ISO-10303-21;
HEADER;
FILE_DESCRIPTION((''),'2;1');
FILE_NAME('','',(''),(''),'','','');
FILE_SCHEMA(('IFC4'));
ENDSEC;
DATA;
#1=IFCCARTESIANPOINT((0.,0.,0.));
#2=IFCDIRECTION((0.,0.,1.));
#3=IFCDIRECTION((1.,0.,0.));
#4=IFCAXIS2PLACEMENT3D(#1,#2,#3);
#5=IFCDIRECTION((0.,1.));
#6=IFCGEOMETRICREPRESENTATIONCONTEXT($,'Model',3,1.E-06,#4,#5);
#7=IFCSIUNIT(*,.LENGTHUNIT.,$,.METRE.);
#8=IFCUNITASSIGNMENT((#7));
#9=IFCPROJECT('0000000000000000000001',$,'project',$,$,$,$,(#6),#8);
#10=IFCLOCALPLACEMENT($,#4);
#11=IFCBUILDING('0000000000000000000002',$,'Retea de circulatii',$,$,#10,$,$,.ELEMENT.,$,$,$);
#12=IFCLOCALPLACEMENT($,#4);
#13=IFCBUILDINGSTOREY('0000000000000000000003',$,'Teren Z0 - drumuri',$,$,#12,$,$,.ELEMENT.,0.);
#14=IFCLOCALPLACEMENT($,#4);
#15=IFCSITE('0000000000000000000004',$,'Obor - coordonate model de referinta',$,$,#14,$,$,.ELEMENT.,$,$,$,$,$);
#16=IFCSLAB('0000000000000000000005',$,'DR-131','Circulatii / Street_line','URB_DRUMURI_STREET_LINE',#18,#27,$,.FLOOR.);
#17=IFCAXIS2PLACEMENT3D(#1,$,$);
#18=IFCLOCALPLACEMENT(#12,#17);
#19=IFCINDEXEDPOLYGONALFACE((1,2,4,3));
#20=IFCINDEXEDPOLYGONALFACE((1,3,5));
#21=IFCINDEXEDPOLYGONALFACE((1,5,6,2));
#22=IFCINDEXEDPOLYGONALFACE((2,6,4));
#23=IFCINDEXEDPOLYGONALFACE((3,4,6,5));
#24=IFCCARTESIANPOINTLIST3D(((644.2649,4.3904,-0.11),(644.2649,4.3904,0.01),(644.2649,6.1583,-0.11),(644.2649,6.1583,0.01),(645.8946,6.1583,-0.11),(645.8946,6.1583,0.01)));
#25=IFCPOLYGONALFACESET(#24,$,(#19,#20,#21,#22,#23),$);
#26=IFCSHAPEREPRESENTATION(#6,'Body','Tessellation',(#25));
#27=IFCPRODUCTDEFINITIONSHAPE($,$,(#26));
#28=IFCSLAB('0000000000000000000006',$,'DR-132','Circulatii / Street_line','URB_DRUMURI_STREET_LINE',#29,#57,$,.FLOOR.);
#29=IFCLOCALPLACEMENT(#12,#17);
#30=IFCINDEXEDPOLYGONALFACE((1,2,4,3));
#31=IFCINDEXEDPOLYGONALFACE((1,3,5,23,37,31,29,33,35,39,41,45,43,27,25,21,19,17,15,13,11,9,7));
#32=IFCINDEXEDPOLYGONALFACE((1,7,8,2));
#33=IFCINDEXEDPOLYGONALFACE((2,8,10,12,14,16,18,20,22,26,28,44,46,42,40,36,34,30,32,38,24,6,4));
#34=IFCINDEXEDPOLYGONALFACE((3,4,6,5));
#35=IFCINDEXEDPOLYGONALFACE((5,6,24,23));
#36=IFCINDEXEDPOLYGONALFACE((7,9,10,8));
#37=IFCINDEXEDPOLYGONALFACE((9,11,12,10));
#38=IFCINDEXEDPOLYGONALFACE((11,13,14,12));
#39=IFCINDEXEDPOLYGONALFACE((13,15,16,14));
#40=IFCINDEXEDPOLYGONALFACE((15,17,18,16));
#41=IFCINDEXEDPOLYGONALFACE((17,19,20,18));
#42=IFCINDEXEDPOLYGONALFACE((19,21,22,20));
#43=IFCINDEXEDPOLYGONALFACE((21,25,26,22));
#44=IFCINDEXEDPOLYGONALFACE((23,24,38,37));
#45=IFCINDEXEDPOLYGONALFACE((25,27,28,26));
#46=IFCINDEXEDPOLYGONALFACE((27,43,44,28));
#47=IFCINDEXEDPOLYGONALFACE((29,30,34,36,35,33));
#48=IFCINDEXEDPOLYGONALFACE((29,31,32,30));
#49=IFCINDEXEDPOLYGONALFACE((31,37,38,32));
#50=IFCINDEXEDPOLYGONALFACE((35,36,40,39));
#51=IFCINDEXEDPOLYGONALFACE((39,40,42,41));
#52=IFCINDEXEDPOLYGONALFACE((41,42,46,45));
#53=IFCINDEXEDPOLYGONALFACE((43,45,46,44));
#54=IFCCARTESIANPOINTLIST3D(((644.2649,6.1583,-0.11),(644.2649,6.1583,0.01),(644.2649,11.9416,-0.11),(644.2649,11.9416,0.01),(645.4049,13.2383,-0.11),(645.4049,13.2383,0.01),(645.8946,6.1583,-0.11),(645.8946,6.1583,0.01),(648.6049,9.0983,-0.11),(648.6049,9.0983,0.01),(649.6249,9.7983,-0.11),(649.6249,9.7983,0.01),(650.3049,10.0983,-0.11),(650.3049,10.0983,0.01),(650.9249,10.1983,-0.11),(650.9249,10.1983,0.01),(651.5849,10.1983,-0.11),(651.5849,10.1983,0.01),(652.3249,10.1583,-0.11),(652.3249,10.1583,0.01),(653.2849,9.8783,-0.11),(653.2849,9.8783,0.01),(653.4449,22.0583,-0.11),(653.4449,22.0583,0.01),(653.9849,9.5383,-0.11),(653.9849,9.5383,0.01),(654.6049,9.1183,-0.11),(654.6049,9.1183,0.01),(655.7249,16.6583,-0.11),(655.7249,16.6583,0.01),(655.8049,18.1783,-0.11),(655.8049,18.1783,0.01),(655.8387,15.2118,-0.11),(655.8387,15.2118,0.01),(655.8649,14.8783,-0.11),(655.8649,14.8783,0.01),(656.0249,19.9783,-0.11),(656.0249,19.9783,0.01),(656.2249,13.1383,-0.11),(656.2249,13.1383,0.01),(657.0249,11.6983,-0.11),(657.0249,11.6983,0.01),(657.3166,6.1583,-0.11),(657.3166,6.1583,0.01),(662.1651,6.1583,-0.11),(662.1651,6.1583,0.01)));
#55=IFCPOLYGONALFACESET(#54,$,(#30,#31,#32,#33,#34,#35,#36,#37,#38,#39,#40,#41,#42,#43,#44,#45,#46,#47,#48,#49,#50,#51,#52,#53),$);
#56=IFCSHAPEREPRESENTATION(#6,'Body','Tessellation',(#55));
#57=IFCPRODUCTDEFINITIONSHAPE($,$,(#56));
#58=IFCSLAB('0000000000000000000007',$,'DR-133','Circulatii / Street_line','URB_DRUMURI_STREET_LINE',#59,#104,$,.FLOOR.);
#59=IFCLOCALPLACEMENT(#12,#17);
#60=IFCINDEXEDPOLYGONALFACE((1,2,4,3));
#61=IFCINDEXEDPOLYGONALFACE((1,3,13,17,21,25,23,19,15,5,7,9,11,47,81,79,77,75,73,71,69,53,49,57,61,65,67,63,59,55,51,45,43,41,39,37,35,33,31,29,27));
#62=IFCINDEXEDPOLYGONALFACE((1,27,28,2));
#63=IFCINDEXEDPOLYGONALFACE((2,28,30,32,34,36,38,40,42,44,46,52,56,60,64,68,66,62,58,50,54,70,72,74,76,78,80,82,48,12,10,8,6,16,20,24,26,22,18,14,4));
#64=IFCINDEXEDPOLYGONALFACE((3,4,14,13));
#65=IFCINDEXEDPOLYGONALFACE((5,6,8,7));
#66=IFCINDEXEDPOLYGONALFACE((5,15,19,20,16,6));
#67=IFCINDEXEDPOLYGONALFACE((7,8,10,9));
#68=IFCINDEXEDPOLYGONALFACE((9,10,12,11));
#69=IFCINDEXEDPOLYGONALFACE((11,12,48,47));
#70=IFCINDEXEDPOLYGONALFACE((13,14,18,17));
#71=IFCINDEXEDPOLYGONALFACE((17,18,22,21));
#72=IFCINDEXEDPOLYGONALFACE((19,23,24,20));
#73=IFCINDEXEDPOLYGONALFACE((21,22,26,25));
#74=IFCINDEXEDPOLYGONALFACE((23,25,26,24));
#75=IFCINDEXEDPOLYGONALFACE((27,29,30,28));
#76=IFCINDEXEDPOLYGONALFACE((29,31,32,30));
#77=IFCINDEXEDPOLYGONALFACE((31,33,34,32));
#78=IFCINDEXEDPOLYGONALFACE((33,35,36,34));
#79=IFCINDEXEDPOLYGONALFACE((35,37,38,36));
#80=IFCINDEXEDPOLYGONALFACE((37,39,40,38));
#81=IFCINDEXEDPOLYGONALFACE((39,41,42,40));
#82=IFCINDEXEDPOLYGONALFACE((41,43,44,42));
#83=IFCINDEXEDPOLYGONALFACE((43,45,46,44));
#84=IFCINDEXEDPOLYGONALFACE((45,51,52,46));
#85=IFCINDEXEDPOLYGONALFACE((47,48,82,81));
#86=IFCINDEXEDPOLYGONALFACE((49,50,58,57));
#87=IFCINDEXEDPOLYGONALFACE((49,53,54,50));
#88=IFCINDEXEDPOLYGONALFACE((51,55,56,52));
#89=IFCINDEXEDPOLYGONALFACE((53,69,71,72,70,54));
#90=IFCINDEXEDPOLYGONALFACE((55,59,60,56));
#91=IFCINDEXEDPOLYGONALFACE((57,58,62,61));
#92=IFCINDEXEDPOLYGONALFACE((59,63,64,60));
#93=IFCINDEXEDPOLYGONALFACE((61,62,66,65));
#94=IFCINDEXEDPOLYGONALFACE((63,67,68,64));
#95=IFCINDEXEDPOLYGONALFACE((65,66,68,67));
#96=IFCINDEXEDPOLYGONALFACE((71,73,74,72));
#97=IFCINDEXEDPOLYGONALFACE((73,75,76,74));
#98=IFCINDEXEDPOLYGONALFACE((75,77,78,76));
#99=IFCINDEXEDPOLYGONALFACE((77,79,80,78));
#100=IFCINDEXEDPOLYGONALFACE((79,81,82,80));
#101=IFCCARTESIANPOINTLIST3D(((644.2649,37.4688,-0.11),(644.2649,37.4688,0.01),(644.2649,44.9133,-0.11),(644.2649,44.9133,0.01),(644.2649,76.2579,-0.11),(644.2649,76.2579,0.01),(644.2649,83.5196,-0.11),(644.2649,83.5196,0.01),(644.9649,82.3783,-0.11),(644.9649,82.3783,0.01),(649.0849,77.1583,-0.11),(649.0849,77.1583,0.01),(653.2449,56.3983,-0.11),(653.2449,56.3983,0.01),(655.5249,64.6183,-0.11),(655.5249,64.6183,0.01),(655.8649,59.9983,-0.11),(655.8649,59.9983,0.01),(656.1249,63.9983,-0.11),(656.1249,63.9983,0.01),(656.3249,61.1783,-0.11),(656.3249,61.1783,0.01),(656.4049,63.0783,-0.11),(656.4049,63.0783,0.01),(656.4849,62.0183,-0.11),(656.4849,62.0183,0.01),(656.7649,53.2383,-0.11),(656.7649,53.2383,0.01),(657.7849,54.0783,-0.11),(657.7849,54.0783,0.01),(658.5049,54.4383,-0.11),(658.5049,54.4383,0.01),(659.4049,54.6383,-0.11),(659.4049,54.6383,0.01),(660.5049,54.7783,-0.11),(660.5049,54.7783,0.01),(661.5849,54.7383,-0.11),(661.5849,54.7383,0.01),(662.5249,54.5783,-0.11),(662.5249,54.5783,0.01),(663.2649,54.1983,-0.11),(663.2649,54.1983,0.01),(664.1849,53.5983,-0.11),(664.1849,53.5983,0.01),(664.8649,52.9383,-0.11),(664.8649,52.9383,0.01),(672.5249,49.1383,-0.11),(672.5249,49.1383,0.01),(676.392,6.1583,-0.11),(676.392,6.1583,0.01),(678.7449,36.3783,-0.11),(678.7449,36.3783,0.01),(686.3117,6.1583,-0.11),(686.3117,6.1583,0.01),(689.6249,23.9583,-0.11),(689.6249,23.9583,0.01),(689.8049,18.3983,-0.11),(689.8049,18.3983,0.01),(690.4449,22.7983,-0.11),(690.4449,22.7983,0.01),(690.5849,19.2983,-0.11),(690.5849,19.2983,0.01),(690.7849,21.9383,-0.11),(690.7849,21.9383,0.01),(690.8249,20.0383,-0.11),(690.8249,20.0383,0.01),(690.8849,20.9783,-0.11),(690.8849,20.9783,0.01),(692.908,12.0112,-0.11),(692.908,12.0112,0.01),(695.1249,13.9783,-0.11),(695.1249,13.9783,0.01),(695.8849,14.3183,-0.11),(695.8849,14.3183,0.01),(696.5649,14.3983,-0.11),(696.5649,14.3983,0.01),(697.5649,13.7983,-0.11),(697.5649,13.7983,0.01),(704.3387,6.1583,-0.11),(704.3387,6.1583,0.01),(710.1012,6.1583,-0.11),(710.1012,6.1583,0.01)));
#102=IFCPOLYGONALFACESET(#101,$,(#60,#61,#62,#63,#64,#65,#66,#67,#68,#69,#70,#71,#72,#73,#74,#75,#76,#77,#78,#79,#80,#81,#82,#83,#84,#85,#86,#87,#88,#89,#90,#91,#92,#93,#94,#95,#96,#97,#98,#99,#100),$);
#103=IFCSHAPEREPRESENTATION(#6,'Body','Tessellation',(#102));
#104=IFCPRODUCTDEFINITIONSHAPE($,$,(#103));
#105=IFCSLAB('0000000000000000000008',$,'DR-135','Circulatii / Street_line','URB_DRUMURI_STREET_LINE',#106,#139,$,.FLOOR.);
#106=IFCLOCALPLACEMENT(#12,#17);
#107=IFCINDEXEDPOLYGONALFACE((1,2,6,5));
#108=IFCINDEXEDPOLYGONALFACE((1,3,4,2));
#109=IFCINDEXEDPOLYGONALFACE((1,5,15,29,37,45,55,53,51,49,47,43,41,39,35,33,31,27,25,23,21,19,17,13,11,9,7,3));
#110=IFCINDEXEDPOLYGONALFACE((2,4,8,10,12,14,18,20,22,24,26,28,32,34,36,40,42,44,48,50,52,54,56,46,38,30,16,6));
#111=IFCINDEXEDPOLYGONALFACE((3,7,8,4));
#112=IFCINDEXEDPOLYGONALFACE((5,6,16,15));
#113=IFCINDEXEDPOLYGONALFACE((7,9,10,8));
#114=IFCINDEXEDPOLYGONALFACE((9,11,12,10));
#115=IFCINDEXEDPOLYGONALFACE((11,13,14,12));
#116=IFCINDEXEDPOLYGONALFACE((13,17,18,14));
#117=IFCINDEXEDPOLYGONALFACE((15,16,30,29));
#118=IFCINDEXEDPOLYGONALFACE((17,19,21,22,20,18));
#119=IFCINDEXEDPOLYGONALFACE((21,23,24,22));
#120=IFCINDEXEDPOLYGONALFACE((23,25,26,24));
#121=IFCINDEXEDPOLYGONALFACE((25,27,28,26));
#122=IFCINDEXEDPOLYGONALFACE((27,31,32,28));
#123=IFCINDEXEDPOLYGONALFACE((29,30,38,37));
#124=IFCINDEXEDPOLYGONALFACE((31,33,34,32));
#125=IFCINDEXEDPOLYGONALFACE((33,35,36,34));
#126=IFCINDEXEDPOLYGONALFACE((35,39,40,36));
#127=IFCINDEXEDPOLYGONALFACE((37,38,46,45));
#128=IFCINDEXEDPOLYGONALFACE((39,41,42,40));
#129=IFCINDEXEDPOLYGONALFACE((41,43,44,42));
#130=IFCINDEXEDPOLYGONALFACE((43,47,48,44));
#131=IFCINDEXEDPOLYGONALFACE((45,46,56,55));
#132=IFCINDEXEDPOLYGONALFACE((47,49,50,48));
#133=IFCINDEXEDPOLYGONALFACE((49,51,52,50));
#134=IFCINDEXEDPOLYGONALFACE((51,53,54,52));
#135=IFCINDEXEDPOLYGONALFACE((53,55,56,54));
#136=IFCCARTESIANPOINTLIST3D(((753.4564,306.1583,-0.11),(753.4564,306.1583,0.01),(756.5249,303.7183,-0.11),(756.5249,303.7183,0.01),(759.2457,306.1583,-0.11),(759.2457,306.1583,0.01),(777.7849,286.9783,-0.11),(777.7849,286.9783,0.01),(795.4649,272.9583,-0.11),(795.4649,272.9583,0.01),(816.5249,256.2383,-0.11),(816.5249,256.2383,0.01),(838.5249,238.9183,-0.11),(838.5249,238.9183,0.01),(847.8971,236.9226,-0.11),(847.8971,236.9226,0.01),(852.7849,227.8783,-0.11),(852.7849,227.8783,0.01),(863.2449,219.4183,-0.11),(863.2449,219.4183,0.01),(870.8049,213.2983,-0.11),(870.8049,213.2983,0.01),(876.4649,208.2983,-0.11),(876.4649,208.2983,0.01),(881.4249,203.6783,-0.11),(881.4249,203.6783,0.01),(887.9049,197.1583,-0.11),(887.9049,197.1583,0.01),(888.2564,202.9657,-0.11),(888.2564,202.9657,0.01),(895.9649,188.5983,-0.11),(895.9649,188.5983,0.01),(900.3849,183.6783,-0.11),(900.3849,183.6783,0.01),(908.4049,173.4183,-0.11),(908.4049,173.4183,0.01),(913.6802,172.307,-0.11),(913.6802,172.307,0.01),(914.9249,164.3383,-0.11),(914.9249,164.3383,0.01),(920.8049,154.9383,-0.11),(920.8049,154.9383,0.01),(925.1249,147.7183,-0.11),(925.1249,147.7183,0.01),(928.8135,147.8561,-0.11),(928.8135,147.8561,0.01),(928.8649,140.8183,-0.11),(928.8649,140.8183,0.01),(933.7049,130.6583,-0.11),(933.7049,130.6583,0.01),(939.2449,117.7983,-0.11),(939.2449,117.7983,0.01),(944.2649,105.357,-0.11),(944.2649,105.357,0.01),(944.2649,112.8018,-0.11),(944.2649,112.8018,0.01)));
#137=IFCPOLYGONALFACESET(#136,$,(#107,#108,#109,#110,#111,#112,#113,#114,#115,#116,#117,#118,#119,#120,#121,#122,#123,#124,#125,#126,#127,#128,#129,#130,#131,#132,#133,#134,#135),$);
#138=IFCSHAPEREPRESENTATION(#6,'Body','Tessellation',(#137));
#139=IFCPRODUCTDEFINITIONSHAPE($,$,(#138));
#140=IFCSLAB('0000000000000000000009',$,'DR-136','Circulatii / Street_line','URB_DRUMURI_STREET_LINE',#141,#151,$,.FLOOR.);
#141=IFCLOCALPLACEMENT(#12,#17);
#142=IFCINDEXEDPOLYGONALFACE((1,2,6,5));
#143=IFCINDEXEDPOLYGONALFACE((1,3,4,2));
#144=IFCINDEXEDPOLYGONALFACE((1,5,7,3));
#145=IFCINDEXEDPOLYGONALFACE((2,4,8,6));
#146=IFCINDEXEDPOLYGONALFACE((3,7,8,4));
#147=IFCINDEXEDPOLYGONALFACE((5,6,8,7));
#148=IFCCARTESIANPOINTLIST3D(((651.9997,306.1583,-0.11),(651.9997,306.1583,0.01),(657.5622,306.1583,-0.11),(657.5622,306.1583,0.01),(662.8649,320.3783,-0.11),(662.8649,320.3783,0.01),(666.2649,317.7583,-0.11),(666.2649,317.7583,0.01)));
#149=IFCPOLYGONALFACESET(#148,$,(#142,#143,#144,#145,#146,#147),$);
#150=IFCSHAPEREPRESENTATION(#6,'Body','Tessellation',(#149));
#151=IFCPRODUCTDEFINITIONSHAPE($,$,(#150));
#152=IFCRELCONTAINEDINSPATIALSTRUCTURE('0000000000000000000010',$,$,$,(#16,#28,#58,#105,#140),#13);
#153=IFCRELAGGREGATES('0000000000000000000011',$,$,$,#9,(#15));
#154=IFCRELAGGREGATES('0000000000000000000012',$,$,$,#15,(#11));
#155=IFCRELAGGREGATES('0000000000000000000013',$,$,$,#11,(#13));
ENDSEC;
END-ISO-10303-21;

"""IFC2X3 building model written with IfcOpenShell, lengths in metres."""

from ifc_helpers import new_model, si_unit, direction, frame, origin_with_axes, place, context, project, spatial, polyline, outline, extrude, element, save


model = new_model("IFC2X3")

# Units and contexts
model_context = context("Model", 3, precision=1e-06, world=origin_with_axes(), true_north=direction((0.0, 1.0)))
ifc_project = project(units=[si_unit("LENGTHUNIT", "METRE")], contexts=[model_context])

# Site, building, storey
site_placement = place(None, origin_with_axes())
site = spatial("IfcSite", under=ifc_project, at=site_placement, Name="Obor - coordonate model de referinta", CompositionType="ELEMENT")
building_placement = place(None, origin_with_axes())
building = spatial("IfcBuilding", under=site, at=building_placement, Name="Retea de circulatii", CompositionType="ELEMENT")
storey_placement = place(None, origin_with_axes())
storey = spatial("IfcBuildingStorey", under=building, at=storey_placement, Name="Teren Z0 - drumuri", CompositionType="ELEMENT", Elevation=0.0)

# Slabs
slab_1_placement = place(None, origin_with_axes())
element("IfcSlab", 1, at=slab_1_placement, inside=storey, Name="DR-131", Description="Circulatii / Street_line", ObjectType="URB_DRUMURI_STREET_LINE", PredefinedType="FLOOR", context=model_context, shape_type="SweptSolid", body=[
    extrude(outline(polyline([(645.8946, 6.1583), (644.2649, 6.1583), (644.2649, 4.3904), (645.8946, 6.1583)])), frame((0.0, 0.0, -0.11), z_axis=(0.0, 0.0, 1.0), x_axis=(1.0, 0.0, 0.0)), (0.0, 0.0, 1.0), 0.12),
])
slab_2_placement = place(None, origin_with_axes())
element("IfcSlab", 2, at=slab_2_placement, inside=storey, Name="DR-132", Description="Circulatii / Street_line", ObjectType="URB_DRUMURI_STREET_LINE", PredefinedType="FLOOR", context=model_context, shape_type="SweptSolid", body=[
    extrude(outline(polyline([(653.2849, 9.8783), (653.9849, 9.5383), (654.6049, 9.1183), (657.3166, 6.1583), (662.1651, 6.1583), (657.0249, 11.6983), (656.2249, 13.1383), (655.8649, 14.8783), (655.8387, 15.2118), (655.7249, 16.6583), (655.8049, 18.1783), (656.0249, 19.9783), (653.4449, 22.0583), (645.4049, 13.2383), (644.2649, 11.9416), (644.2649, 6.1583), (645.8946, 6.1583), (648.6049, 9.0983), (649.6249, 9.7983), (650.3049, 10.0983), (650.9249, 10.1983), (651.5849, 10.1983), (652.3249, 10.1583), (653.2849, 9.8783)])), frame((0.0, 0.0, -0.11), z_axis=(0.0, 0.0, 1.0), x_axis=(1.0, 0.0, 0.0)), (0.0, 0.0, 1.0), 0.12),
])
slab_3_placement = place(None, origin_with_axes())
element("IfcSlab", 3, at=slab_3_placement, inside=storey, Name="DR-133", Description="Circulatii / Street_line", ObjectType="URB_DRUMURI_STREET_LINE", PredefinedType="FLOOR", context=model_context, shape_type="SweptSolid", body=[
    extrude(outline(polyline([(695.8849, 14.3183), (696.5649, 14.3983), (697.5649, 13.7983), (704.3387, 6.1583), (710.1012, 6.1583), (672.5249, 49.1383), (649.0849, 77.1583), (644.9649, 82.3783), (644.2649, 83.5196), (644.2649, 76.2579), (655.5249, 64.6183), (656.1249, 63.9983), (656.4049, 63.0783), (656.4849, 62.0183), (656.3249, 61.1783), (655.8649, 59.9983), (653.2449, 56.3983), (644.2649, 44.9133), (644.2649, 37.4688), (656.7649, 53.2383), (657.7849, 54.0783), (658.5049, 54.4383), (659.4049, 54.6383), (660.5049, 54.7783), (661.5849, 54.7383), (662.5249, 54.5783), (663.2649, 54.1983), (664.1849, 53.5983), (664.8649, 52.9383), (678.7449, 36.3783), (689.6249, 23.9583), (690.4449, 22.7983), (690.7849, 21.9383), (690.8849, 20.9783), (690.8249, 20.0383), (690.5849, 19.2983), (689.8049, 18.3983), (676.392, 6.1583), (686.3117, 6.1583), (692.908, 12.0112), (695.1249, 13.9783), (695.8849, 14.3183)])), frame((0.0, 0.0, -0.11), z_axis=(0.0, 0.0, 1.0), x_axis=(1.0, 0.0, 0.0)), (0.0, 0.0, 1.0), 0.12),
])
slab_4_placement = place(None, origin_with_axes())
element("IfcSlab", 4, at=slab_4_placement, inside=storey, Name="DR-135", Description="Circulatii / Street_line", ObjectType="URB_DRUMURI_STREET_LINE", PredefinedType="FLOOR", context=model_context, shape_type="SweptSolid", body=[
    extrude(outline(polyline([(913.6802, 172.307), (888.2564, 202.9657), (847.8971, 236.9226), (759.2457, 306.1583), (753.4564, 306.1583), (756.5249, 303.7183), (777.7849, 286.9783), (795.4649, 272.9583), (816.5249, 256.2383), (838.5249, 238.9183), (852.7849, 227.8783), (863.2449, 219.4183), (870.8049, 213.2983), (876.4649, 208.2983), (881.4249, 203.6783), (887.9049, 197.1583), (895.9649, 188.5983), (900.3849, 183.6783), (908.4049, 173.4183), (914.9249, 164.3383), (920.8049, 154.9383), (925.1249, 147.7183), (928.8649, 140.8183), (933.7049, 130.6583), (939.2449, 117.7983), (944.2649, 105.357), (944.2649, 112.8018), (928.8135, 147.8561), (913.6802, 172.307)])), frame((0.0, 0.0, -0.11), z_axis=(0.0, 0.0, 1.0), x_axis=(1.0, 0.0, 0.0)), (0.0, 0.0, 1.0), 0.12),
])
slab_5_placement = place(None, origin_with_axes())
element("IfcSlab", 5, at=slab_5_placement, inside=storey, Name="DR-136", Description="Circulatii / Street_line", ObjectType="URB_DRUMURI_STREET_LINE", PredefinedType="FLOOR", context=model_context, shape_type="SweptSolid", body=[
    extrude(outline(polyline([(666.2649, 317.7583), (662.8649, 320.3783), (651.9997, 306.1583), (657.5622, 306.1583), (666.2649, 317.7583)])), frame((0.0, 0.0, -0.11), z_axis=(0.0, 0.0, 1.0), x_axis=(1.0, 0.0, 0.0)), (0.0, 0.0, 1.0), 0.12),
])

save(model, "model.ifc")
